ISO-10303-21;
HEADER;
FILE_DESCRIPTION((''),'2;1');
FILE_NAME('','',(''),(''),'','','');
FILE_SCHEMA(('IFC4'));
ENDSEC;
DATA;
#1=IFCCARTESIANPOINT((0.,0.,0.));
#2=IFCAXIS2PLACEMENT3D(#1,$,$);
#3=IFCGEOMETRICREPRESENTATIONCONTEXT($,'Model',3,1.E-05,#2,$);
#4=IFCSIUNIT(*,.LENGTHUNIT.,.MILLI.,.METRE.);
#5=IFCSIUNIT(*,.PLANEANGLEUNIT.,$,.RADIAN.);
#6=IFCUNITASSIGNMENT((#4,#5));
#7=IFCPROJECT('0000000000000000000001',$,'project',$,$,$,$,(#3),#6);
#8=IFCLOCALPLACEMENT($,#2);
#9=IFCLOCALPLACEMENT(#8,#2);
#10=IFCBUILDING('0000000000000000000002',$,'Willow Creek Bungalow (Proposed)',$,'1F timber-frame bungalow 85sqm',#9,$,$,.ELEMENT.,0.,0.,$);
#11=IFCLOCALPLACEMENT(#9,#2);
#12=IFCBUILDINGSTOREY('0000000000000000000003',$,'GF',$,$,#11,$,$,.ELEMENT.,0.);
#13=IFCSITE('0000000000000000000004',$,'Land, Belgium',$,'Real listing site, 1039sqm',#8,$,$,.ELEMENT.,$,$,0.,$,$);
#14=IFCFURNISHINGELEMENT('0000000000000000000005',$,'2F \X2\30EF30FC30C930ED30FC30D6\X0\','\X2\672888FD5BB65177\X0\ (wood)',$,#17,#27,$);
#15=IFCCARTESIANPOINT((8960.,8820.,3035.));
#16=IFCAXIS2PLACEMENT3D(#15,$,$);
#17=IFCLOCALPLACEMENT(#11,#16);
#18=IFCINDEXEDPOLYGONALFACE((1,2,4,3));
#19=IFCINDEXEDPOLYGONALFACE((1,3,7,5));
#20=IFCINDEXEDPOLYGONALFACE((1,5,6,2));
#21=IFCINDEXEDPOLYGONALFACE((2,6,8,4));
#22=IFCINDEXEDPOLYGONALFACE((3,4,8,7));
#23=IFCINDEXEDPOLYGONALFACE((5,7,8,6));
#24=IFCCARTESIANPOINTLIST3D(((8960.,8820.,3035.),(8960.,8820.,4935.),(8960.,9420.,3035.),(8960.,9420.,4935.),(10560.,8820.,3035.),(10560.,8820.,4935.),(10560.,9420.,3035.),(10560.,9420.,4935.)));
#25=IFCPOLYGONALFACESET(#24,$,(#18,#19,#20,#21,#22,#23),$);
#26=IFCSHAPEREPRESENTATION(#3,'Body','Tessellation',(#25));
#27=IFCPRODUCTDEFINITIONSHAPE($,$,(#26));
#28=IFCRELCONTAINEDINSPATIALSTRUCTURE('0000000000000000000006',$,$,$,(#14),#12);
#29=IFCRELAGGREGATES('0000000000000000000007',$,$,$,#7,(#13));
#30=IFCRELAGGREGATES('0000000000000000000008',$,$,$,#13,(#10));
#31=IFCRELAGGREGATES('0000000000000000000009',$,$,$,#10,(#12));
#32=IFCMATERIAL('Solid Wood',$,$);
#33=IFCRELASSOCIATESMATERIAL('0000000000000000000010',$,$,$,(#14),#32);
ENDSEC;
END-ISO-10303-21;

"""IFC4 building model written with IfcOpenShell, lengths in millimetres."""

from ifc_helpers import new_model, si_unit, frame, frame_2d, origin, place, context, project, spatial, rectangle, extrude, material, element, save


model = new_model("IFC4")

# Units and contexts
model_context = context("Model", 3, precision=1e-05, world=origin())
ifc_project = project(units=[si_unit("LENGTHUNIT", "METRE", prefix="MILLI"), si_unit("PLANEANGLEUNIT", "RADIAN")], contexts=[model_context])

# Site, building, storey
site_placement = place(None, origin())
site = spatial("IfcSite", under=ifc_project, at=site_placement, Name="Land, Belgium", ObjectType="Real listing site, 1039sqm", CompositionType="ELEMENT", RefElevation=0.0)
building_placement = place(site_placement, origin())
building = spatial("IfcBuilding", under=site, at=building_placement, Name="Willow Creek Bungalow (Proposed)", ObjectType="1F timber-frame bungalow 85sqm", CompositionType="ELEMENT", ElevationOfRefHeight=0.0, ElevationOfTerrain=0.0)
storey_placement = place(building_placement, origin())
storey = spatial("IfcBuildingStorey", under=building, at=storey_placement, Name="GF", CompositionType="ELEMENT", Elevation=0.0)

# Shared definitions
ifc_material_1 = material(Name="Solid Wood")

# Furnishing element
furnishing_1_placement = place(storey_placement, frame((8960.0, 8820.0, 3035.0)))
element("IfcFurnishingElement", 1, at=furnishing_1_placement, inside=storey, material=ifc_material_1, Name="2F ワードローブ", Description="木製家具 (wood)", context=model_context, shape_type="SweptSolid", body=[
    extrude(rectangle(XDim=1600.0, YDim=600.0, at=frame_2d((800.0, 300.0))), frame((8960.0, 8820.0, 3035.0)), (0.0, 0.0, 1.0), 1900.0),
])

save(model, "model.ifc")
